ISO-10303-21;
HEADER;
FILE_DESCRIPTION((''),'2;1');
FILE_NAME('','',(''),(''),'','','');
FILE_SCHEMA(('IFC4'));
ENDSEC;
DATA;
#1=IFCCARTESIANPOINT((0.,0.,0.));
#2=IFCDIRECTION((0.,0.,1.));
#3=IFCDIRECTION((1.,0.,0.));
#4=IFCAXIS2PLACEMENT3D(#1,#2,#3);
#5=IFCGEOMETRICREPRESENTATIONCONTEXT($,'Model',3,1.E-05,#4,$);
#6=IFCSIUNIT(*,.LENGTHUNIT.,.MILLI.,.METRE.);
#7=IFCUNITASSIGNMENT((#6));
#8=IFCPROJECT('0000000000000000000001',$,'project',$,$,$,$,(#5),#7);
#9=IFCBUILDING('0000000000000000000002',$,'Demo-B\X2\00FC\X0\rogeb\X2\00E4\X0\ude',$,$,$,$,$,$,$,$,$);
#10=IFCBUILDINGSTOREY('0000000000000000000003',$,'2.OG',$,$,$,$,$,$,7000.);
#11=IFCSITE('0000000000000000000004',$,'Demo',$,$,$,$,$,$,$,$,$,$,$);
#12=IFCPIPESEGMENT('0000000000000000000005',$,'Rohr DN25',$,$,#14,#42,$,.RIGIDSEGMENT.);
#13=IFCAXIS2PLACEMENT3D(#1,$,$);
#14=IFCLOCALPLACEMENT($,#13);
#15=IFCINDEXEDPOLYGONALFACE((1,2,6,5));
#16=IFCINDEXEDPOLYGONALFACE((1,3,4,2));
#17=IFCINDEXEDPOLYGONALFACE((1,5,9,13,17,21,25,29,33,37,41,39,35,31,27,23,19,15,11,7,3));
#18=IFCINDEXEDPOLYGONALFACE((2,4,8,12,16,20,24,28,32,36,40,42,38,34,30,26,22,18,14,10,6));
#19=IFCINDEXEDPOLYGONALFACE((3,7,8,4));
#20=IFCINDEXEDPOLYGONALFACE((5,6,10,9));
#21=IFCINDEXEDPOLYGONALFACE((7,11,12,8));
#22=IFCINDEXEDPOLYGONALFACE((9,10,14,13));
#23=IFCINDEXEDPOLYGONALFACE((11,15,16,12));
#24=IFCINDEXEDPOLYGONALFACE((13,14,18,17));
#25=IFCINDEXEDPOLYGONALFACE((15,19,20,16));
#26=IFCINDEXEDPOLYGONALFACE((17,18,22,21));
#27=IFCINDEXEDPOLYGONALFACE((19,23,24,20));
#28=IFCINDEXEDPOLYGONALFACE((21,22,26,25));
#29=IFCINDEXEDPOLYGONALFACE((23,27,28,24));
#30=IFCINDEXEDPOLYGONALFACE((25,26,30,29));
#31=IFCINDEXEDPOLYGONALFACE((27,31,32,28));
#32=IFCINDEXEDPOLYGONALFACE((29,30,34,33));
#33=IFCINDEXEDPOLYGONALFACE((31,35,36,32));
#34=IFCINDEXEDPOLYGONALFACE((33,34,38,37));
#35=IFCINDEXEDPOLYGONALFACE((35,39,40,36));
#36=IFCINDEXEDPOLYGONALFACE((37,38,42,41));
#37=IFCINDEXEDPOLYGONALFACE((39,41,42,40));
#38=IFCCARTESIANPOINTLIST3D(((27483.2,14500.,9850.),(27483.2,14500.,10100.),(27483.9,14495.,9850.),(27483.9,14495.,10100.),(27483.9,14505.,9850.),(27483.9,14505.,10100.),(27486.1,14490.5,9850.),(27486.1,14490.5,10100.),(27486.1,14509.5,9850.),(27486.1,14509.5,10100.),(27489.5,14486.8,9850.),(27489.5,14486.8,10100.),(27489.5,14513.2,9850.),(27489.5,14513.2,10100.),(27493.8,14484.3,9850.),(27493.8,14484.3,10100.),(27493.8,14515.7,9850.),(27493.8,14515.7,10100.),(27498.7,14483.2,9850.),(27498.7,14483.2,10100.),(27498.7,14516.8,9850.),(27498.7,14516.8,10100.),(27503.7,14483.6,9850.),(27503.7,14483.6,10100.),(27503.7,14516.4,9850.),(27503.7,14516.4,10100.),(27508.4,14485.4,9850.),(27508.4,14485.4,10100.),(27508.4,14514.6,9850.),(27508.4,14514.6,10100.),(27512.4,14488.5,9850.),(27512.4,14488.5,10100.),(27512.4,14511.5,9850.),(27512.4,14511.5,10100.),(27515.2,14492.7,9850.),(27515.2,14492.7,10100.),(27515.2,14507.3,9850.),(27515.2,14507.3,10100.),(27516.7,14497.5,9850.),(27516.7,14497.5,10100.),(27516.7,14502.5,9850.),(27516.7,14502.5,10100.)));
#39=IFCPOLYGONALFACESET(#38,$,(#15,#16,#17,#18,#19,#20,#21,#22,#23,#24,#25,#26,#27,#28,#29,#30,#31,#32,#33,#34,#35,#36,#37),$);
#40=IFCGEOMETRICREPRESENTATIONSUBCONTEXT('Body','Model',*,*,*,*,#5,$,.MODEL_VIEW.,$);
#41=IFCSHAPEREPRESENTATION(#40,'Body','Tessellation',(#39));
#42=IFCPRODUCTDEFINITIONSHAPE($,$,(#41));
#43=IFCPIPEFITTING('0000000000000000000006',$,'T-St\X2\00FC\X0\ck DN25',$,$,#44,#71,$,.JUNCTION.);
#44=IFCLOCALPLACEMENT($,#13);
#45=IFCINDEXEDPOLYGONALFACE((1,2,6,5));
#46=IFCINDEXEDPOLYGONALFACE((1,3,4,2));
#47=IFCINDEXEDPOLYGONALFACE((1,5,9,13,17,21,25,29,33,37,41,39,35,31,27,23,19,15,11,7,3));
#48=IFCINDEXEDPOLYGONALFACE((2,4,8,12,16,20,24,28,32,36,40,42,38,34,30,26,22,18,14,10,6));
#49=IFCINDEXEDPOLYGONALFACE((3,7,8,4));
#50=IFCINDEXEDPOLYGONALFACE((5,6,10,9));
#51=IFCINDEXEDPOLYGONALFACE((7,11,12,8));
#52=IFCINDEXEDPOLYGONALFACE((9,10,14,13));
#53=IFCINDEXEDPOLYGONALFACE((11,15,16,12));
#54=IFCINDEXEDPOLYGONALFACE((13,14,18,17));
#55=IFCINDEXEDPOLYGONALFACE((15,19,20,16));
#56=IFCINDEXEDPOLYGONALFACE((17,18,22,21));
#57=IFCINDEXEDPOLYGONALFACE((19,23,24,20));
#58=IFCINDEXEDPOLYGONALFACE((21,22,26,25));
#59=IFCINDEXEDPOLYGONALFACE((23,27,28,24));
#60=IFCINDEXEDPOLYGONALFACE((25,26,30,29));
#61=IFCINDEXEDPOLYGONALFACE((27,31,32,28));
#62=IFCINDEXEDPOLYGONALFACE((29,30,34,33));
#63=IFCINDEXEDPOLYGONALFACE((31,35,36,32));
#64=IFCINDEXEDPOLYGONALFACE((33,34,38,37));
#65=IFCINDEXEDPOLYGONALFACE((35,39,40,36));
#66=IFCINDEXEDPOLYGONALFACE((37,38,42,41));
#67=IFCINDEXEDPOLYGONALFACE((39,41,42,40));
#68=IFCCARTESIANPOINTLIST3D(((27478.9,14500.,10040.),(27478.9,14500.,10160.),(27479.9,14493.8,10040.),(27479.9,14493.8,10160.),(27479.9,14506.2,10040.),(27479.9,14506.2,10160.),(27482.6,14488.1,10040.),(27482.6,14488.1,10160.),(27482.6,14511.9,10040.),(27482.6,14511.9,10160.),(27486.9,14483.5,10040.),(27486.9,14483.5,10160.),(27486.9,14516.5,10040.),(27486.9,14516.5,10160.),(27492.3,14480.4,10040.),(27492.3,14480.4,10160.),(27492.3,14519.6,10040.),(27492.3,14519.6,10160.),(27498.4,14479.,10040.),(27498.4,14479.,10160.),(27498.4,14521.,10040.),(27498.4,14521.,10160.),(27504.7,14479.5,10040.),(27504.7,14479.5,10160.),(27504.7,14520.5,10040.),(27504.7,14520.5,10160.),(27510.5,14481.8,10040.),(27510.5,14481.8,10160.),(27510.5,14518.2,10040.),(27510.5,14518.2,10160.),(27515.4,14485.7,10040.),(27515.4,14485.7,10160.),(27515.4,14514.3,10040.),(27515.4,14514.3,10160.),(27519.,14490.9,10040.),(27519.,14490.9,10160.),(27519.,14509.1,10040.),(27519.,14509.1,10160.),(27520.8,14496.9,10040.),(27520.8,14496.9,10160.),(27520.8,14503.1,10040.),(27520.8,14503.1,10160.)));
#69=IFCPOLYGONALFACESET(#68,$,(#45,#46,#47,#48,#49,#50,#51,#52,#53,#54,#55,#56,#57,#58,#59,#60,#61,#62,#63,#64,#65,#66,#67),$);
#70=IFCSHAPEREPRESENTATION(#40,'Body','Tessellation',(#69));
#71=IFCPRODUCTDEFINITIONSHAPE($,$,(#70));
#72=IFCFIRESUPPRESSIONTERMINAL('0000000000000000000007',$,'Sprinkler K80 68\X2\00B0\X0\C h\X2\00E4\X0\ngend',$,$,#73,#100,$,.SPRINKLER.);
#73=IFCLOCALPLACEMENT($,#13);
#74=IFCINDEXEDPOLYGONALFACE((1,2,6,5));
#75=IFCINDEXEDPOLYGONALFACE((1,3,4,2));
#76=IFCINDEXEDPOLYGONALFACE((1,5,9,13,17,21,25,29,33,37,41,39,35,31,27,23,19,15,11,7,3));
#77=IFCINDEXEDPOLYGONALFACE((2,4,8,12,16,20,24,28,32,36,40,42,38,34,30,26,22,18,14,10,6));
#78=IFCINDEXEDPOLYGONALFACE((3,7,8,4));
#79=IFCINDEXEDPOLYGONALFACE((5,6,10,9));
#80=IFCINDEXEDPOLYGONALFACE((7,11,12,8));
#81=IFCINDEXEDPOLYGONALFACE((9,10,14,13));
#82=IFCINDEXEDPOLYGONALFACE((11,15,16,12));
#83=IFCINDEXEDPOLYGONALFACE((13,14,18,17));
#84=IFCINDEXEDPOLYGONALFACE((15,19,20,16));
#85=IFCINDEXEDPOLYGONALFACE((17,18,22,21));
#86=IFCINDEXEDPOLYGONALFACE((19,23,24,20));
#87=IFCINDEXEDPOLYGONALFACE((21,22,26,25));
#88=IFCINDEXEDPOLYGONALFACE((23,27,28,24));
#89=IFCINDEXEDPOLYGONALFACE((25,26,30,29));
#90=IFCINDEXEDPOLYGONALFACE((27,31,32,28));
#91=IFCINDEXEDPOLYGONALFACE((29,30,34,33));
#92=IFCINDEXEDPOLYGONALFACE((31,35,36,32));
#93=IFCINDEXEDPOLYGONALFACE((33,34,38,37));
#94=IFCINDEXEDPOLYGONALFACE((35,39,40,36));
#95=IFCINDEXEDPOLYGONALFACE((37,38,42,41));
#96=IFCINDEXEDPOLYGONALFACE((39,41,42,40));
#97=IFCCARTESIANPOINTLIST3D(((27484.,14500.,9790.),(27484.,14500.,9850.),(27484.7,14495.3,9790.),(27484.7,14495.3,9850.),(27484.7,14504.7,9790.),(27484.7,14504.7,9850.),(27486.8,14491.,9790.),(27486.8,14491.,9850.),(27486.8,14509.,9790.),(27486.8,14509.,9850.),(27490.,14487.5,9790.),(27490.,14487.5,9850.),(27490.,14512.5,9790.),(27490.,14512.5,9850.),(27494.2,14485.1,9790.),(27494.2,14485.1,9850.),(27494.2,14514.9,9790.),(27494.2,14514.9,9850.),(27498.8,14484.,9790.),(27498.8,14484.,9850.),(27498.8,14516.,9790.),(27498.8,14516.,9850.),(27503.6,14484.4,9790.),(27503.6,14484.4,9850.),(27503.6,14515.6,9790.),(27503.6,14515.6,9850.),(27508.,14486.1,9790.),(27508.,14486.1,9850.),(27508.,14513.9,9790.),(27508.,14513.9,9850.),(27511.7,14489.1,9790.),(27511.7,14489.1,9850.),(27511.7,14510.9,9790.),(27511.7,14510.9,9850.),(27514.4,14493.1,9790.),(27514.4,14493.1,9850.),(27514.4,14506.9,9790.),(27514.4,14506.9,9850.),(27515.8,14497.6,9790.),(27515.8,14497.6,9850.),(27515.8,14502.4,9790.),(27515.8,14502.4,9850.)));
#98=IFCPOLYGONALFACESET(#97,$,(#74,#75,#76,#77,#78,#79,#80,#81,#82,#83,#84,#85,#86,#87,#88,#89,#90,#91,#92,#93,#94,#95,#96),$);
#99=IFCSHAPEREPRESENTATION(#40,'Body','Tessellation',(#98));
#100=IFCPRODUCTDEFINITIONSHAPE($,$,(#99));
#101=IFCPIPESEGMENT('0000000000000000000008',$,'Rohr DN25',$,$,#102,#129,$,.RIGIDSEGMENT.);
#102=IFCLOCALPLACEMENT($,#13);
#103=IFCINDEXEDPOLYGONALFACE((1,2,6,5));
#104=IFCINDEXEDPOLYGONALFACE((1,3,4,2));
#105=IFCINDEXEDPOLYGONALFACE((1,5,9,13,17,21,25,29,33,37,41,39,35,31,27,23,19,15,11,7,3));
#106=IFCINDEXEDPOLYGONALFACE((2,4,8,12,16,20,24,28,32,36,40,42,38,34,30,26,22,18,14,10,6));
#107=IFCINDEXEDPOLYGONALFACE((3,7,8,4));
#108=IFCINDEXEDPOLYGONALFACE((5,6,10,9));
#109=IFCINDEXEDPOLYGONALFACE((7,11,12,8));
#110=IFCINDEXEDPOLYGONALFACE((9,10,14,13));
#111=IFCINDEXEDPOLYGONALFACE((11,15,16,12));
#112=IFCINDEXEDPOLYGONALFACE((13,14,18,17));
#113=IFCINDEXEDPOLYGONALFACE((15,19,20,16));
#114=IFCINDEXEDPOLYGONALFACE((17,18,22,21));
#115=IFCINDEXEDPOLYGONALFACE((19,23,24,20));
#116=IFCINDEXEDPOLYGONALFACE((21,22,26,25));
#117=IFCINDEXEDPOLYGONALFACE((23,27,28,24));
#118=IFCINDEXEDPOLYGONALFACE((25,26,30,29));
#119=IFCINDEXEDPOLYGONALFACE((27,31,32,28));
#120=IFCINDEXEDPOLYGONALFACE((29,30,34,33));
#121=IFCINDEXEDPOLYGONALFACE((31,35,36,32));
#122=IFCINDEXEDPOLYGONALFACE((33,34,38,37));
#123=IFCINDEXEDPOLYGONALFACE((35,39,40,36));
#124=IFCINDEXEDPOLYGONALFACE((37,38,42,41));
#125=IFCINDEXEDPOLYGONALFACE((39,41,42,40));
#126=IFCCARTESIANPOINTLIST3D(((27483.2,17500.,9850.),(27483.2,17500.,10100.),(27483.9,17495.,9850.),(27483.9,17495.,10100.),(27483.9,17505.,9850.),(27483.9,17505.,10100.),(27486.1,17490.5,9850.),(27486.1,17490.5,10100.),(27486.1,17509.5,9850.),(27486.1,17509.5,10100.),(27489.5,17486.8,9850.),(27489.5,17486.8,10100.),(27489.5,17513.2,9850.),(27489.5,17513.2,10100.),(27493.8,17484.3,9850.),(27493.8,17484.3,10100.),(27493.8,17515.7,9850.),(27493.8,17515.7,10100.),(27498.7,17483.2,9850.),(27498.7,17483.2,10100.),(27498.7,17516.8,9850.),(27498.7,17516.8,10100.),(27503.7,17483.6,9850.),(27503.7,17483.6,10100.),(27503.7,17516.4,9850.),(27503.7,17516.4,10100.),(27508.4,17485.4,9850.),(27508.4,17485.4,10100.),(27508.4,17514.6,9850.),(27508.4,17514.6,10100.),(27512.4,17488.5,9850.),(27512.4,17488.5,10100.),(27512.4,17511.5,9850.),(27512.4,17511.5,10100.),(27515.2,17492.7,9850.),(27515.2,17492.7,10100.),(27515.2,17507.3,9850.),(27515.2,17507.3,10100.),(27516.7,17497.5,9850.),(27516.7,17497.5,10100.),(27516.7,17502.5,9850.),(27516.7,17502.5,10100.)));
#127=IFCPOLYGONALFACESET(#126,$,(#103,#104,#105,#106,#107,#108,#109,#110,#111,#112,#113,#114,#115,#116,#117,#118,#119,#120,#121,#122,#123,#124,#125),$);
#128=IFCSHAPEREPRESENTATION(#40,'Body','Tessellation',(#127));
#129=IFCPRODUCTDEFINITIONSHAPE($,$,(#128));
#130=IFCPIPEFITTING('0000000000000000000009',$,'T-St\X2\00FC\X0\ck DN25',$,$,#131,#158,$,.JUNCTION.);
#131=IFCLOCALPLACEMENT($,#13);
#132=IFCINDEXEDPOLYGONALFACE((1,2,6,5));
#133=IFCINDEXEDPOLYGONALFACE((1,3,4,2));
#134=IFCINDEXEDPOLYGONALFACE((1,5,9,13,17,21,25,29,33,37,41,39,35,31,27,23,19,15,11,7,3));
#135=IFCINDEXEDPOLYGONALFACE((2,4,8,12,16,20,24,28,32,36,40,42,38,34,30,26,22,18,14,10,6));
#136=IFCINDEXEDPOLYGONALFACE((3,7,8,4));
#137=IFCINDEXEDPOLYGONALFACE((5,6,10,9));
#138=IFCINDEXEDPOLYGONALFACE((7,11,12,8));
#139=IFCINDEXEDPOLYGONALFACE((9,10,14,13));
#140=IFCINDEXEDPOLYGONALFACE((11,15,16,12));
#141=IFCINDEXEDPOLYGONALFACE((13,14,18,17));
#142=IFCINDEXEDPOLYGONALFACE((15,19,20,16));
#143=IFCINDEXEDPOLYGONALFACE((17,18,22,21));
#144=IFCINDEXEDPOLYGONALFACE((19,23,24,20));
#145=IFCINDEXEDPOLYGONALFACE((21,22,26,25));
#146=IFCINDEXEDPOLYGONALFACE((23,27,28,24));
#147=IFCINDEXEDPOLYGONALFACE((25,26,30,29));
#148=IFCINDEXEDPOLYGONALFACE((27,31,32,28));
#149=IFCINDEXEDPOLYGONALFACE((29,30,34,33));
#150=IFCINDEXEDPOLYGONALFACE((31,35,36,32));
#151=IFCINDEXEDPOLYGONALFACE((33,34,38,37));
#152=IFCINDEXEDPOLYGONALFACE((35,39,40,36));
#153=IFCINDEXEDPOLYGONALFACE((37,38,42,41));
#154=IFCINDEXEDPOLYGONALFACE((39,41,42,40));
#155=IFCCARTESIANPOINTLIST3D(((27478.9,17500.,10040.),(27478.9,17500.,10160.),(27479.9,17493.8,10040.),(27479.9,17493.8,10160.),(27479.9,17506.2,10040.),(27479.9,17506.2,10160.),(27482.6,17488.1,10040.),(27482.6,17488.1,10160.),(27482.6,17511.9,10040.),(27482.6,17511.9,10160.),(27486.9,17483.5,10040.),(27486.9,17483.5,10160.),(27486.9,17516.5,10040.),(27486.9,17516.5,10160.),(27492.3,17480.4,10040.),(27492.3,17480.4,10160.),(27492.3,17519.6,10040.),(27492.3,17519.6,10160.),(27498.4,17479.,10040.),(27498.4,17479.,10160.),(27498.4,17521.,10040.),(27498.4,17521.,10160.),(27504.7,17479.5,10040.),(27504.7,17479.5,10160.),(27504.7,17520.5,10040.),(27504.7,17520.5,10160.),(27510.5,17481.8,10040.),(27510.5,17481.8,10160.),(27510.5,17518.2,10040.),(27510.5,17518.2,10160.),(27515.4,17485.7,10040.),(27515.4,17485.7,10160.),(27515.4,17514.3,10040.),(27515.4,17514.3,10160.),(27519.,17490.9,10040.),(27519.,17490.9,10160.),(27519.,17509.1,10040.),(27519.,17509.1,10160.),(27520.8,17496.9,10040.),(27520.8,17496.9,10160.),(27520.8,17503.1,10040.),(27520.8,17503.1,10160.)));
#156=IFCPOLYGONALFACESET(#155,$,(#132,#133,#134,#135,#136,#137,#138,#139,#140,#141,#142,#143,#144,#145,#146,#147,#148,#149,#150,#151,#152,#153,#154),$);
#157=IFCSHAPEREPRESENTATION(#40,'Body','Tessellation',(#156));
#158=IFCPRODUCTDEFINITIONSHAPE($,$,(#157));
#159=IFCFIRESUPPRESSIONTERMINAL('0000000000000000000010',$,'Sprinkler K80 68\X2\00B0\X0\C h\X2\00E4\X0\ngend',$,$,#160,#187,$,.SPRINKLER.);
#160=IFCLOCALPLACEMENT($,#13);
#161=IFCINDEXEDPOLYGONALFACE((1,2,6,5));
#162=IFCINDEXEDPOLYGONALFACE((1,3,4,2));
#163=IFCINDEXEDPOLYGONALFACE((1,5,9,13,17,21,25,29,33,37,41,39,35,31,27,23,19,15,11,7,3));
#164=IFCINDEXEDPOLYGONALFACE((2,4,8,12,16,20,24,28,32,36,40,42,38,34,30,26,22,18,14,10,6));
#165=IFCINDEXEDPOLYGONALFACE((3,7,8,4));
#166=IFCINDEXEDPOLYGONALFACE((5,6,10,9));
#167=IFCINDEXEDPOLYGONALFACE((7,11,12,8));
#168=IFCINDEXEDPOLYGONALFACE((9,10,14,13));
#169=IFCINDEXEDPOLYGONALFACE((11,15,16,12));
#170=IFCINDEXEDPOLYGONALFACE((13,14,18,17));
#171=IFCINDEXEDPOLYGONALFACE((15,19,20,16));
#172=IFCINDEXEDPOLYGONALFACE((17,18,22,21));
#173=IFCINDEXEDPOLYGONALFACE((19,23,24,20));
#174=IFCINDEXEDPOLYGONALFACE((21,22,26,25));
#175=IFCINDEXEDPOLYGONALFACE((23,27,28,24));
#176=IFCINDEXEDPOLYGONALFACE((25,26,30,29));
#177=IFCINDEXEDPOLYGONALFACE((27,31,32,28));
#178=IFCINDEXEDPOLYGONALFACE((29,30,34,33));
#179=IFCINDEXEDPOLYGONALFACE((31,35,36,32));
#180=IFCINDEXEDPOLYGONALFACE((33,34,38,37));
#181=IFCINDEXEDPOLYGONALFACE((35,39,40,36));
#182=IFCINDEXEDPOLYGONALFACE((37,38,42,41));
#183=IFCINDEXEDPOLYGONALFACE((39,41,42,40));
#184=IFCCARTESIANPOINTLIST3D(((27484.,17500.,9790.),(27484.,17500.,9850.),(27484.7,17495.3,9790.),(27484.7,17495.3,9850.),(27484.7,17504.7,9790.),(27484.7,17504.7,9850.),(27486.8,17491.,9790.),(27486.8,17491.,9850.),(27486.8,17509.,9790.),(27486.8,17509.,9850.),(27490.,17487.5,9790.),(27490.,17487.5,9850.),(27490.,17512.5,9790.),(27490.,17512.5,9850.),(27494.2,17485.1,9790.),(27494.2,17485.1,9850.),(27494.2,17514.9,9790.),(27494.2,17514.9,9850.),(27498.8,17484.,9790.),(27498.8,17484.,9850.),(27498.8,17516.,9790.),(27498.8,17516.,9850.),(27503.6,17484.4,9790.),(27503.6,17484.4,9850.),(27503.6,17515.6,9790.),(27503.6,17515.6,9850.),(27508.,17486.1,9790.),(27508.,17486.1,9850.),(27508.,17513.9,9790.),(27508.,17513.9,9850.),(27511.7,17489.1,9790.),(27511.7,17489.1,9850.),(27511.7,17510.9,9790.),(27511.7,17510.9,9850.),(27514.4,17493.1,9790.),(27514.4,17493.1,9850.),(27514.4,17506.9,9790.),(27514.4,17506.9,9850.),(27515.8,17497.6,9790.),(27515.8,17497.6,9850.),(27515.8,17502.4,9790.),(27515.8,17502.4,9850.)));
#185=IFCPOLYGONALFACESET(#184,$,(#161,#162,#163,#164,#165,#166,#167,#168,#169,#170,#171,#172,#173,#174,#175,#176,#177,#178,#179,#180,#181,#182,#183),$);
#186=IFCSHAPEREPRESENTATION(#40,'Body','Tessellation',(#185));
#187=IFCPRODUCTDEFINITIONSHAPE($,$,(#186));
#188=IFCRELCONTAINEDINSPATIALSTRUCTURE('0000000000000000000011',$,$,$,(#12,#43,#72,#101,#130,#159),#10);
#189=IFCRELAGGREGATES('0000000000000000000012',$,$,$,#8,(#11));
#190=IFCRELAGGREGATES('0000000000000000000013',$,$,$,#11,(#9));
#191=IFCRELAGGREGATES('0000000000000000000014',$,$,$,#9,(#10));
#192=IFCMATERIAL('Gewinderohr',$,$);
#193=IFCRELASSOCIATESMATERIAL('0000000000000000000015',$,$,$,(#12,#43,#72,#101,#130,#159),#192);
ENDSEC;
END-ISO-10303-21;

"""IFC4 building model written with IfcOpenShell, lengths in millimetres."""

from ifc_helpers import new_model, si_unit, frame, origin_with_axes, place, context, subcontext, project, spatial, circle, extrude, material, element, save


model = new_model("IFC4")

# Units and contexts
model_context = context("Model", 3, precision=1e-05, world=origin_with_axes())
body_context = subcontext(model_context, "Body", "Model", "MODEL_VIEW")
ifc_project = project(units=[si_unit("LENGTHUNIT", "METRE", prefix="MILLI")], contexts=[model_context])

# Site, building, storey
site = spatial("IfcSite", under=ifc_project, Name="Demo")
building = spatial("IfcBuilding", under=site, Name="Demo-Bürogebäude")
storey = spatial("IfcBuildingStorey", under=building, Name="2.OG", Elevation=7000.0)

# Shared definitions
ifc_material_1 = material(Name="Gewinderohr")

# Pipe segment
pipe_segment_1_placement = place(None, frame((27500.0, 14500.0, 10100.0), z_axis=(0.0, 0.0, -1.0), x_axis=(-1.0, 0.0, 0.0)))
element("IfcPipeSegment", 1, at=pipe_segment_1_placement, inside=storey, material=ifc_material_1, Name="Rohr DN25", PredefinedType="RIGIDSEGMENT", context=body_context, shape_type="SweptSolid", body=[
    extrude(circle(Radius=16.9), origin_with_axes(), (0.0, 0.0, 1.0), 250.0),
])

# Pipe fitting
pipe_fitting_1_placement = place(None, frame((27500.0, 14500.0, 10160.0), z_axis=(0.0, 0.0, -1.0), x_axis=(-1.0, 0.0, 0.0)))
element("IfcPipeFitting", 2, at=pipe_fitting_1_placement, inside=storey, material=ifc_material_1, Name="T-Stück DN25", PredefinedType="JUNCTION", context=body_context, shape_type="SweptSolid", body=[
    extrude(circle(Radius=21.1), origin_with_axes(), (0.0, 0.0, 1.0), 120.0),
])

# Fire suppression terminal
fire_suppression_terminal_1_placement = place(None, frame((27500.0, 14500.0, 9850.0), z_axis=(0.0, 0.0, -1.0), x_axis=(-1.0, 0.0, 0.0)))
element("IfcFireSuppressionTerminal", 3, at=fire_suppression_terminal_1_placement, inside=storey, material=ifc_material_1, Name="Sprinkler K80 68°C hängend", PredefinedType="SPRINKLER", context=body_context, shape_type="SweptSolid", body=[
    extrude(circle(Radius=16.0), origin_with_axes(), (0.0, 0.0, 1.0), 60.0),
])

# Pipe segment
pipe_segment_2_placement = place(None, frame((27500.0, 17500.0, 10100.0), z_axis=(0.0, 0.0, -1.0), x_axis=(-1.0, 0.0, 0.0)))
element("IfcPipeSegment", 4, at=pipe_segment_2_placement, inside=storey, material=ifc_material_1, Name="Rohr DN25", PredefinedType="RIGIDSEGMENT", context=body_context, shape_type="SweptSolid", body=[
    extrude(circle(Radius=16.9), origin_with_axes(), (0.0, 0.0, 1.0), 250.0),
])

# Pipe fitting
pipe_fitting_2_placement = place(None, frame((27500.0, 17500.0, 10160.0), z_axis=(0.0, 0.0, -1.0), x_axis=(-1.0, 0.0, 0.0)))
element("IfcPipeFitting", 5, at=pipe_fitting_2_placement, inside=storey, material=ifc_material_1, Name="T-Stück DN25", PredefinedType="JUNCTION", context=body_context, shape_type="SweptSolid", body=[
    extrude(circle(Radius=21.1), origin_with_axes(), (0.0, 0.0, 1.0), 120.0),
])

# Fire suppression terminal
fire_suppression_terminal_2_placement = place(None, frame((27500.0, 17500.0, 9850.0), z_axis=(0.0, 0.0, -1.0), x_axis=(-1.0, 0.0, 0.0)))
element("IfcFireSuppressionTerminal", 6, at=fire_suppression_terminal_2_placement, inside=storey, material=ifc_material_1, Name="Sprinkler K80 68°C hängend", PredefinedType="SPRINKLER", context=body_context, shape_type="SweptSolid", body=[
    extrude(circle(Radius=16.0), origin_with_axes(), (0.0, 0.0, 1.0), 60.0),
])

save(model, "model.ifc")
